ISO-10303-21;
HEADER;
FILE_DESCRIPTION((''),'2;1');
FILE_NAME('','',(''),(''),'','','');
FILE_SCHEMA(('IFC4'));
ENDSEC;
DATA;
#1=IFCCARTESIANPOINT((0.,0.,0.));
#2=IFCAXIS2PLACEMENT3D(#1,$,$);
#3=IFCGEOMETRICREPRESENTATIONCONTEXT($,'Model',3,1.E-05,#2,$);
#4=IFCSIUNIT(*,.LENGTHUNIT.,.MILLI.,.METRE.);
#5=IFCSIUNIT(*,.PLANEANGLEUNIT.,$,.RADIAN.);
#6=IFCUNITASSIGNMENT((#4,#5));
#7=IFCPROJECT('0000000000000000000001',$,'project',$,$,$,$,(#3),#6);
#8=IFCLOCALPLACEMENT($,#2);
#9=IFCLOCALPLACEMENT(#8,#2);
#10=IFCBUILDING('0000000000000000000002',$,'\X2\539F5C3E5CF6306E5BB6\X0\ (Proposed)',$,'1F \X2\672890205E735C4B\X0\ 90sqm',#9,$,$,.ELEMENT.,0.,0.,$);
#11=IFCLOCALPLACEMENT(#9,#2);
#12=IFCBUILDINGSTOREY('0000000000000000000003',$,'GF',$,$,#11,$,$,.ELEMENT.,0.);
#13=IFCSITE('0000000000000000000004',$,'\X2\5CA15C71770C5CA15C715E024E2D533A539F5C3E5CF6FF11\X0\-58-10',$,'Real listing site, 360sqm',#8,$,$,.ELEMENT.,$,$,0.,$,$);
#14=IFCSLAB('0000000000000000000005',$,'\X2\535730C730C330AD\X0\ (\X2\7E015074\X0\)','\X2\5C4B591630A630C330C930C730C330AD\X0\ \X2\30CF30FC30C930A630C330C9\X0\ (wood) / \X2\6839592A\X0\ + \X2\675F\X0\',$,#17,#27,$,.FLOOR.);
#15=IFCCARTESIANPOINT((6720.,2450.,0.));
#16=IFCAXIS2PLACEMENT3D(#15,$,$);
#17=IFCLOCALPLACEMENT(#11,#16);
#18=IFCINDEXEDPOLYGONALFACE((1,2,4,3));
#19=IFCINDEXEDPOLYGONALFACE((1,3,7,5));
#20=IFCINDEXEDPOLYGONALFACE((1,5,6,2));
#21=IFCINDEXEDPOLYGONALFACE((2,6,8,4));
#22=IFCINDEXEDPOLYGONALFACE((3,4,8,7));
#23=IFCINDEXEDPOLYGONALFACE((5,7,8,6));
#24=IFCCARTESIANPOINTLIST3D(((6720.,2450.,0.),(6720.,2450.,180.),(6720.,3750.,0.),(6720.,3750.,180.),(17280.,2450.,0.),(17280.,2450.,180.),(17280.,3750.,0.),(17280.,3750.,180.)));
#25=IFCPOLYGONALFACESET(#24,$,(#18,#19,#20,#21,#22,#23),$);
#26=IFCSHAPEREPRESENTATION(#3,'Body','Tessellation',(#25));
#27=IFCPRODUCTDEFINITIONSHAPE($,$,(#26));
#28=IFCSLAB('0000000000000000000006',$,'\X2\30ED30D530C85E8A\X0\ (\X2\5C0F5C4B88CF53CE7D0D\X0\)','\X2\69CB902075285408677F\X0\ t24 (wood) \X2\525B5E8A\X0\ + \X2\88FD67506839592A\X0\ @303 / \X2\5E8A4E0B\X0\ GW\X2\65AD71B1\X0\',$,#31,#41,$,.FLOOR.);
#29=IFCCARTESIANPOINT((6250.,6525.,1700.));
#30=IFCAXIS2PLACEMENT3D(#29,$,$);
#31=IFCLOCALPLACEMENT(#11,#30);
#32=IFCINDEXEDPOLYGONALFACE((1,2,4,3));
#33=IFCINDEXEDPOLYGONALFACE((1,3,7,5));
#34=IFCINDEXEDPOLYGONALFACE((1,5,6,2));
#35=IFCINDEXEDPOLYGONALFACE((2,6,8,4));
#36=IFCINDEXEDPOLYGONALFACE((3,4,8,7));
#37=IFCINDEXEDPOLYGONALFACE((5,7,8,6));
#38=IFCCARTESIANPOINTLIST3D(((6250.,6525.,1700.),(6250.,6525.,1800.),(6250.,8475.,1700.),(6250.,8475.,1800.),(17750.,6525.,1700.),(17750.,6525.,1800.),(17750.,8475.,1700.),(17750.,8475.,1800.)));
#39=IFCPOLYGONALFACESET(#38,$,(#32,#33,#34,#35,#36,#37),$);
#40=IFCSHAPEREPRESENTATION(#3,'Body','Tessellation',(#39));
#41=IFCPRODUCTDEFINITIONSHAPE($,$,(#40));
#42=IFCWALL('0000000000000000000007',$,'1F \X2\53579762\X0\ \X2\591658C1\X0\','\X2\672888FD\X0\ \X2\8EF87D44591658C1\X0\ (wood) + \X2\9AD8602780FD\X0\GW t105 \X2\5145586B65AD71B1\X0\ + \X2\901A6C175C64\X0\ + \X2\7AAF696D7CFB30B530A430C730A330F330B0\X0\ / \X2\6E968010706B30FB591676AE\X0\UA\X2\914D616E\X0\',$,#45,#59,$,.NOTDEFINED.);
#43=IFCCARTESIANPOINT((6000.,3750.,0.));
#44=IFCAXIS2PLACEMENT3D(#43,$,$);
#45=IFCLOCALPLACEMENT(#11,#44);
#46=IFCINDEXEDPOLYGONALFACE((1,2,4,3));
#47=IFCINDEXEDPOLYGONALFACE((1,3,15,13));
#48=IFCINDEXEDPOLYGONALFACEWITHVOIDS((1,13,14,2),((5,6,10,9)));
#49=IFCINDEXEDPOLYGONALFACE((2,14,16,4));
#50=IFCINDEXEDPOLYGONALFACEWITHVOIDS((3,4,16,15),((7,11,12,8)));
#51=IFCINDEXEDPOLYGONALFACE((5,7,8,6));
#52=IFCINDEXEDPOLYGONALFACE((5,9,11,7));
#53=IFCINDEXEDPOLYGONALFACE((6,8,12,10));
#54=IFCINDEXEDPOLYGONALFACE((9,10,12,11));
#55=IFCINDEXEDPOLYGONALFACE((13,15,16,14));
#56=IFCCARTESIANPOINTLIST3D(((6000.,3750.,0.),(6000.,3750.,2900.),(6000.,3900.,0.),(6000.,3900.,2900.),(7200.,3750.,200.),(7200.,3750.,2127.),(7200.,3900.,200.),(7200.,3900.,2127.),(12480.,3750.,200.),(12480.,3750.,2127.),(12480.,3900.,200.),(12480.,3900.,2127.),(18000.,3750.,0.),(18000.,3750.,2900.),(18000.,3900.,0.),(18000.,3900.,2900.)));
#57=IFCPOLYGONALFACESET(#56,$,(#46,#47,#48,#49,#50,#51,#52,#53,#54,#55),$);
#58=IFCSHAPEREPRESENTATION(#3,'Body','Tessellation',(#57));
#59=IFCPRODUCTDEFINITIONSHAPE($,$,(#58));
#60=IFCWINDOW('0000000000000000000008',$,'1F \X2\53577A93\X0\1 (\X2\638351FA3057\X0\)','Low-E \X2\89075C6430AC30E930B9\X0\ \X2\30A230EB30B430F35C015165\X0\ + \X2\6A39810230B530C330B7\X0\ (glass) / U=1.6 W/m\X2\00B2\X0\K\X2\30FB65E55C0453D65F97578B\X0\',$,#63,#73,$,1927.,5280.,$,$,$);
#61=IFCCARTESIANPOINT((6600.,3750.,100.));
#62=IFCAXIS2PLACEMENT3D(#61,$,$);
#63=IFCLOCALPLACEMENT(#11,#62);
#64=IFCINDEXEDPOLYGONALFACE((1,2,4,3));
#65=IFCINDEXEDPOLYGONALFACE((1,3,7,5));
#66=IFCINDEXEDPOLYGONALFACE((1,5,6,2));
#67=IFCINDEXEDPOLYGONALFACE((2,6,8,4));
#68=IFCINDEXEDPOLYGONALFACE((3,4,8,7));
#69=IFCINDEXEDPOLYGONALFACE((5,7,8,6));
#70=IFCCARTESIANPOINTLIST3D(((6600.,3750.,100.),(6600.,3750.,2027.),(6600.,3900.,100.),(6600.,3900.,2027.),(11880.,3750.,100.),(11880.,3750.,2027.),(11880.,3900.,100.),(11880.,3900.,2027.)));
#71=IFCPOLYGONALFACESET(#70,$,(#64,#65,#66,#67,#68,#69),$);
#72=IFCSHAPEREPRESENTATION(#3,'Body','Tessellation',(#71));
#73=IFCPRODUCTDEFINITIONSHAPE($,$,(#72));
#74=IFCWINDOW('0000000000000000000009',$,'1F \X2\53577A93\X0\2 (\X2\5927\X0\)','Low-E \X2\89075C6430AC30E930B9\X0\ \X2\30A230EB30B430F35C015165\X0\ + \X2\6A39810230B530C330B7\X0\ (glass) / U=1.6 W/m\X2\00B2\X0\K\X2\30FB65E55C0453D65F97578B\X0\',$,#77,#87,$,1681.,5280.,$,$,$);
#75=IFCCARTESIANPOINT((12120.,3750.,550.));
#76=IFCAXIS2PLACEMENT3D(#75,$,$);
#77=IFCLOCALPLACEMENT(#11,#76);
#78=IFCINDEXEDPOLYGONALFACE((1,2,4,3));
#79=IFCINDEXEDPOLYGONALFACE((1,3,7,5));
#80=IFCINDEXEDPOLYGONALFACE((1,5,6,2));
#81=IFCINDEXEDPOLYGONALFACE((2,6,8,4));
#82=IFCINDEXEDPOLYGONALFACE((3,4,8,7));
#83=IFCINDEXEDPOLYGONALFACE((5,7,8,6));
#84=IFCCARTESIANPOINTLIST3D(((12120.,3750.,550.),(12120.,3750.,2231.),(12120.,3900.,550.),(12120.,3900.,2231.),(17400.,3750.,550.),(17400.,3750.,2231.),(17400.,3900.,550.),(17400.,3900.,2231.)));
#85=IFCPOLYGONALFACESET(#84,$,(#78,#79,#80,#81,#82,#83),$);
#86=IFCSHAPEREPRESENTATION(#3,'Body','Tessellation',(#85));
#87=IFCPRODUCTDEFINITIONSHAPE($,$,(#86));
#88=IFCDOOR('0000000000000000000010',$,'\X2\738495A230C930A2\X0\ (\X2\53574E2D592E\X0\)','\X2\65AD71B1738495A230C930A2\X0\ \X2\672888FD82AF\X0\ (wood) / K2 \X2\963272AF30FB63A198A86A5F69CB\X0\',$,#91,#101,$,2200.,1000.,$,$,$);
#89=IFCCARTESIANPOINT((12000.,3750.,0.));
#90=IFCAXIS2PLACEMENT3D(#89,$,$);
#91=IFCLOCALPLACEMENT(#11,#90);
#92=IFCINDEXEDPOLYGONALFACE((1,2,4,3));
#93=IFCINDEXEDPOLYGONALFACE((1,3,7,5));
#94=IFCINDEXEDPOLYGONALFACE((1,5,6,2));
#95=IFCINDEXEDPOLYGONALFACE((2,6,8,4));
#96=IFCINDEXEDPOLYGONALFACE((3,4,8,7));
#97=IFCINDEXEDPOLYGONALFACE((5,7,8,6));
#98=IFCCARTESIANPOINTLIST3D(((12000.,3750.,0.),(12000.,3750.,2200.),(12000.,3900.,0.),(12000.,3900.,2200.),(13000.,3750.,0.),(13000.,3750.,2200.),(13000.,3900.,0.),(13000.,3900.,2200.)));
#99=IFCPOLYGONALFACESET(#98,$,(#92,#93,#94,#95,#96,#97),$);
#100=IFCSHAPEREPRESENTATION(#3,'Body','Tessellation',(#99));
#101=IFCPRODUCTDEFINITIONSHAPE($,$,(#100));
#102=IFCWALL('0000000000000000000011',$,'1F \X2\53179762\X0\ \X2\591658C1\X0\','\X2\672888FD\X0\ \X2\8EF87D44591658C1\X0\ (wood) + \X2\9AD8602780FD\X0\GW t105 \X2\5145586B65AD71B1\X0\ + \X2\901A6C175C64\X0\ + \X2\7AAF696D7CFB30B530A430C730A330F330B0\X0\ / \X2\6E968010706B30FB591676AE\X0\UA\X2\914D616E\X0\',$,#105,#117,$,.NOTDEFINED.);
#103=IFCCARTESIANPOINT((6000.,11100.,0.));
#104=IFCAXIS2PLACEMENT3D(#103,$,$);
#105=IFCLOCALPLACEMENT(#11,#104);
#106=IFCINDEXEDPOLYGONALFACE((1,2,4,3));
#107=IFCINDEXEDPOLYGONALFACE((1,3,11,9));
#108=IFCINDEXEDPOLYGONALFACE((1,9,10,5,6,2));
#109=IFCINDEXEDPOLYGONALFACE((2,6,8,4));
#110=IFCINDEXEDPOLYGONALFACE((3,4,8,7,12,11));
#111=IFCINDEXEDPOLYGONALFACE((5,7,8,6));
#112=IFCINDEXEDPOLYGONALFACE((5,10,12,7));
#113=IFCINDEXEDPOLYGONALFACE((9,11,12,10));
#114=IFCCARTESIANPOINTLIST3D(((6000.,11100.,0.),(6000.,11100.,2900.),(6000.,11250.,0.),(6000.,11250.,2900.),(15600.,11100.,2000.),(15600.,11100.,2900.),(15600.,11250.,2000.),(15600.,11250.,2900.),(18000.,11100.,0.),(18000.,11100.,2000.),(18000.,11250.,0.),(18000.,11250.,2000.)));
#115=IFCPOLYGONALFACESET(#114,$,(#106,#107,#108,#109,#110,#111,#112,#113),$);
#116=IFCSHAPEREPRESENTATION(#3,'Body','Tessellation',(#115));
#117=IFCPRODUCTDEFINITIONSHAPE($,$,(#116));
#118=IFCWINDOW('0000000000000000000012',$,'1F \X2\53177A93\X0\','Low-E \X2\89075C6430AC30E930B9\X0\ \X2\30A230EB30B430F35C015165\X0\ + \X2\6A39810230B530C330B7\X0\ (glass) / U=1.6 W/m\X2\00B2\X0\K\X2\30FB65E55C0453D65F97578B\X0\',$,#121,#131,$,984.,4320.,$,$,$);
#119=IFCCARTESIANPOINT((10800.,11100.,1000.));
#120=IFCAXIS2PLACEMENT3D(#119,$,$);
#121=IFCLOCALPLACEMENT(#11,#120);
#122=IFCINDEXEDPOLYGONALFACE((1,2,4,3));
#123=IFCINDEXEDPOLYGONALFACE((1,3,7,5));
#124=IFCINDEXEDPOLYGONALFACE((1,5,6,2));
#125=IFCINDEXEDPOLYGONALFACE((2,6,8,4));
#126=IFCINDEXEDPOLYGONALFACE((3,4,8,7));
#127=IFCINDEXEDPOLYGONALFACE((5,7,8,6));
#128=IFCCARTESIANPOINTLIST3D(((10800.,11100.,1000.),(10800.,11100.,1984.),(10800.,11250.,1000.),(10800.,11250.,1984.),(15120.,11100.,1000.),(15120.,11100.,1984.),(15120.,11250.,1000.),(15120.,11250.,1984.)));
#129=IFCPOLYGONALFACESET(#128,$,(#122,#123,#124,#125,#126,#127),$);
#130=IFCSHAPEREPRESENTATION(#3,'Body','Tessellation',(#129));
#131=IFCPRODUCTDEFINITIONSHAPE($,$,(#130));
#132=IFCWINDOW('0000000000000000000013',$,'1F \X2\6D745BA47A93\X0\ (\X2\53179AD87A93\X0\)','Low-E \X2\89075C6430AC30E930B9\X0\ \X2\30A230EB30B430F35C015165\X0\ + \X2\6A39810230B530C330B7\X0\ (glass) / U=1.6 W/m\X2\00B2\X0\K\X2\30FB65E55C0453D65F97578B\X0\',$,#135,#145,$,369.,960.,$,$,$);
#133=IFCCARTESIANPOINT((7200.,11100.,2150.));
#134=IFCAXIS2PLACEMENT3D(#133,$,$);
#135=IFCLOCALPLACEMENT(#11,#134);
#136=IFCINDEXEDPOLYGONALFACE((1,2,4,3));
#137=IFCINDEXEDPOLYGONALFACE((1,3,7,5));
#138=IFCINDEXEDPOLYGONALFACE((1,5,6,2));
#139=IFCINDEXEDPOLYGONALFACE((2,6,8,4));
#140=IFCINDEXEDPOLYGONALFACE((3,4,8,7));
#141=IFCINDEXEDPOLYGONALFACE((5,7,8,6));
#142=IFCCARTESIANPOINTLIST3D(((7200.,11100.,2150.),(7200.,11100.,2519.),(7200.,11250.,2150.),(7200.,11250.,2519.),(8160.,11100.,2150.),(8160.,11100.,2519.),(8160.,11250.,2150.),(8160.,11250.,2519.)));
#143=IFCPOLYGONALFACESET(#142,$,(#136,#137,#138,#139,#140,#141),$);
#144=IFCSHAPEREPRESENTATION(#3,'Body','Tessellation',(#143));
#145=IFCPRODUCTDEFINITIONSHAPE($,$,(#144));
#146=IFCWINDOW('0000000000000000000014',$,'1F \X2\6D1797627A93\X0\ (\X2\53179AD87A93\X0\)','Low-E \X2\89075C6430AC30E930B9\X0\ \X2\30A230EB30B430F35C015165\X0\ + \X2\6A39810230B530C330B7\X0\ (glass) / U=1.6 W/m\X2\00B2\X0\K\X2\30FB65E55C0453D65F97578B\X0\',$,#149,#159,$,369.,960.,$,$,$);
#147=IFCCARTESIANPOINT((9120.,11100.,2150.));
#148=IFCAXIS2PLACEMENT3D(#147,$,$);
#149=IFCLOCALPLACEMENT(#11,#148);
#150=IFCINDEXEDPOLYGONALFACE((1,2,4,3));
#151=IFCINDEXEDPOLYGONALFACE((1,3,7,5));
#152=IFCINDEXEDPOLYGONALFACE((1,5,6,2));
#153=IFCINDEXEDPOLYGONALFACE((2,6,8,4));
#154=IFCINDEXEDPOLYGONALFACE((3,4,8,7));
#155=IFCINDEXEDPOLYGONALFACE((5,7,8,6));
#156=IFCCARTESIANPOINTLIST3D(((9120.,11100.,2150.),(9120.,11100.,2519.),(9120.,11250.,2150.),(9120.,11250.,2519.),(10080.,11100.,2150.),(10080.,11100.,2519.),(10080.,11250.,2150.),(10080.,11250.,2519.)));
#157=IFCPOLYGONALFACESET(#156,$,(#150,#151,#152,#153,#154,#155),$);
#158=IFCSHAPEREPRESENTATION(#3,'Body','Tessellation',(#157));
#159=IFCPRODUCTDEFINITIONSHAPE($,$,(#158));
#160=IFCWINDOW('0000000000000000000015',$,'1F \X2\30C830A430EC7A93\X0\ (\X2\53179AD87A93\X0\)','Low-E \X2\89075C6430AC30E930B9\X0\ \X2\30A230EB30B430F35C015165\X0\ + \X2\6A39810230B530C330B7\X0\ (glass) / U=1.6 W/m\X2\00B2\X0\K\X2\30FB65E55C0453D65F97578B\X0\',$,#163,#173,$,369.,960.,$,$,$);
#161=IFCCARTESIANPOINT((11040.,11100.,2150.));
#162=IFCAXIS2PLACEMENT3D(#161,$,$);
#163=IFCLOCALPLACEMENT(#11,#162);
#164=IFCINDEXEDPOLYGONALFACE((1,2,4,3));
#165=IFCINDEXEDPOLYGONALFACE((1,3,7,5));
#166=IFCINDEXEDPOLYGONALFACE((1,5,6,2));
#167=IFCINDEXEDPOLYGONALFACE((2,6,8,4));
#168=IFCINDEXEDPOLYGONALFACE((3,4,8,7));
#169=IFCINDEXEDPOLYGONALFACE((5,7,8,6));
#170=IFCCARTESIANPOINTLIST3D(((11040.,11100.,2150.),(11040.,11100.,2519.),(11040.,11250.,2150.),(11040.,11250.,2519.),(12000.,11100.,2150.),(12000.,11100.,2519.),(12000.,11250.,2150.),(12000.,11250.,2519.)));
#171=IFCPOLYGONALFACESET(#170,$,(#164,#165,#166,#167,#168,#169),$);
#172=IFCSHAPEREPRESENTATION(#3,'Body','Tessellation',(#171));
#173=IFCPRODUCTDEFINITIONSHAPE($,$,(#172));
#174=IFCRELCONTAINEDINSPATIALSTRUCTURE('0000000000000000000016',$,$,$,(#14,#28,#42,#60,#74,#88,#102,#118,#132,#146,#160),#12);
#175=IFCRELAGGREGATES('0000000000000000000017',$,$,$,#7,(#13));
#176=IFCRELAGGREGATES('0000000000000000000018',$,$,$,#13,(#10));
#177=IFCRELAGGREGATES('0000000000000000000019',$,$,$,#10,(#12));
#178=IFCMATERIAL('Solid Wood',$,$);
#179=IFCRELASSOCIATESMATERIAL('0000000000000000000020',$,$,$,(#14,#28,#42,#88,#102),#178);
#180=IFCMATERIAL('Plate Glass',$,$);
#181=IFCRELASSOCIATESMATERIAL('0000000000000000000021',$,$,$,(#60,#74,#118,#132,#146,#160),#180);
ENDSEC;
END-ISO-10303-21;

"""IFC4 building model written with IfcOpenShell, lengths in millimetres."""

from ifc_helpers import new_model, si_unit, frame, frame_2d, origin, place, context, project, spatial, rectangle, extrude, material, element, fill, save


model = new_model("IFC4")

# Units and contexts
model_context = context("Model", 3, precision=1e-05, world=origin())
ifc_project = project(units=[si_unit("LENGTHUNIT", "METRE", prefix="MILLI"), si_unit("PLANEANGLEUNIT", "RADIAN")], contexts=[model_context])

# Site, building, storey
site_placement = place(None, origin())
site = spatial("IfcSite", under=ifc_project, at=site_placement, Name="岡山県岡山市中区原尾島１-58-10", ObjectType="Real listing site, 360sqm", CompositionType="ELEMENT", RefElevation=0.0)
building_placement = place(site_placement, origin())
building = spatial("IfcBuilding", under=site, at=building_placement, Name="原尾島の家 (Proposed)", ObjectType="1F 木造平屋 90sqm", CompositionType="ELEMENT", ElevationOfRefHeight=0.0, ElevationOfTerrain=0.0)
storey_placement = place(building_placement, origin())
storey = spatial("IfcBuildingStorey", under=building, at=storey_placement, Name="GF", CompositionType="ELEMENT", Elevation=0.0)

# Slabs
ifc_material_1 = material(Name="Solid Wood")
slab_1_placement = place(storey_placement, frame((6720.0, 2450.0, 0.0)))
element("IfcSlab", 1, at=slab_1_placement, inside=storey, material=ifc_material_1, Name="南デッキ (縁側)", Description="屋外ウッドデッキ ハードウッド (wood) / 根太 + 束", PredefinedType="FLOOR", context=model_context, shape_type="SweptSolid", body=[
    extrude(rectangle(XDim=10560.0, YDim=1300.0, at=frame_2d((5280.0, 650.0))), frame((6720.0, 2450.0, 0.0)), (0.0, 0.0, 1.0), 180.0),
])
slab_2_placement = place(storey_placement, frame((6250.0, 6525.0, 1700.0)))
element("IfcSlab", 2, at=slab_2_placement, inside=storey, material=ifc_material_1, Name="ロフト床 (小屋裏収納)", Description="構造用合板 t24 (wood) 剛床 + 製材根太 @303 / 床下 GW断熱", PredefinedType="FLOOR", context=model_context, shape_type="SweptSolid", body=[
    extrude(rectangle(XDim=11500.0, YDim=1950.0, at=frame_2d((5750.0, 975.0))), frame((6250.0, 6525.0, 1700.0)), (0.0, 0.0, 1.0), 100.0),
])

# Wall, openings, windows, door
wall_1_placement = place(storey_placement, frame((6000.0, 3750.0, 0.0)))
wall_1 = element("IfcWall", 3, at=wall_1_placement, inside=storey, material=ifc_material_1, Name="1F 南面 外壁", Description="木製 軸組外壁 (wood) + 高性能GW t105 充填断熱 + 通気層 + 窯業系サイディング / 準耐火・外皮UA配慮", PredefinedType="NOTDEFINED", context=model_context, shape_type="SweptSolid", body=[
    extrude(rectangle(XDim=12000.0, YDim=150.0, at=frame_2d((6000.0, 75.0))), frame((6000.0, 3750.0, 0.0)), (0.0, 0.0, 1.0), 2900.0),
])
opening_1_placement = place(storey_placement, frame((6600.0, 3750.0, 100.0)))
opening_1 = element("IfcOpeningElement", 4, at=opening_1_placement, cuts=wall_1, PredefinedType="NOTDEFINED", context=model_context, shape_type="SweptSolid", body=[
    extrude(rectangle(XDim=5280.0, YDim=150.0, at=frame_2d((2640.0, 75.0))), frame((6600.0, 3750.0, 100.0)), (0.0, 0.0, 1.0), 1927.0),
])
opening_2_placement = place(storey_placement, frame((12120.0, 3750.0, 550.0)))
opening_2 = element("IfcOpeningElement", 5, at=opening_2_placement, cuts=wall_1, PredefinedType="NOTDEFINED", context=model_context, shape_type="SweptSolid", body=[
    extrude(rectangle(XDim=5280.0, YDim=150.0, at=frame_2d((2640.0, 75.0))), frame((12120.0, 3750.0, 550.0)), (0.0, 0.0, 1.0), 1681.0),
])
opening_3_placement = place(storey_placement, frame((12000.0, 3750.0, 0.0)))
opening_3 = element("IfcOpeningElement", 6, at=opening_3_placement, cuts=wall_1, PredefinedType="NOTDEFINED", context=model_context, shape_type="SweptSolid", body=[
    extrude(rectangle(XDim=1000.0, YDim=150.0, at=frame_2d((500.0, 75.0))), frame((12000.0, 3750.0, 0.0)), (0.0, 0.0, 1.0), 2200.0),
])
ifc_material_2 = material(Name="Plate Glass")
window_1_placement = place(storey_placement, frame((6600.0, 3750.0, 100.0)))
window_1 = element("IfcWindow", 7, at=window_1_placement, inside=storey, material=ifc_material_2, Name="1F 南窓1 (掃出し)", Description="Low-E 複層ガラス アルゴン封入 + 樹脂サッシ (glass) / U=1.6 W/m²K・日射取得型", OverallHeight=1927.0, OverallWidth=5280.0, context=model_context, shape_type="SweptSolid", body=[
    extrude(rectangle(XDim=5280.0, YDim=150.0, at=frame_2d((2640.0, 75.0))), frame((6600.0, 3750.0, 100.0)), (0.0, 0.0, 1.0), 1927.0),
])
fill(opening_1, window_1)
window_2_placement = place(storey_placement, frame((12120.0, 3750.0, 550.0)))
window_2 = element("IfcWindow", 8, at=window_2_placement, inside=storey, material=ifc_material_2, Name="1F 南窓2 (大)", Description="Low-E 複層ガラス アルゴン封入 + 樹脂サッシ (glass) / U=1.6 W/m²K・日射取得型", OverallHeight=1681.0, OverallWidth=5280.0, context=model_context, shape_type="SweptSolid", body=[
    extrude(rectangle(XDim=5280.0, YDim=150.0, at=frame_2d((2640.0, 75.0))), frame((12120.0, 3750.0, 550.0)), (0.0, 0.0, 1.0), 1681.0),
])
fill(opening_2, window_2)
door_1_placement = place(storey_placement, frame((12000.0, 3750.0, 0.0)))
door_1 = element("IfcDoor", 9, at=door_1_placement, inside=storey, material=ifc_material_1, Name="玄関ドア (南中央)", Description="断熱玄関ドア 木製芯 (wood) / K2 防犯・採風機構", OverallHeight=2200.0, OverallWidth=1000.0, context=model_context, shape_type="SweptSolid", body=[
    extrude(rectangle(XDim=1000.0, YDim=150.0, at=frame_2d((500.0, 75.0))), frame((12000.0, 3750.0, 0.0)), (0.0, 0.0, 1.0), 2200.0),
])
fill(opening_3, door_1)

# Wall, openings, windows
wall_2_placement = place(storey_placement, frame((6000.0, 11100.0, 0.0)))
wall_2 = element("IfcWall", 10, at=wall_2_placement, inside=storey, material=ifc_material_1, Name="1F 北面 外壁", Description="木製 軸組外壁 (wood) + 高性能GW t105 充填断熱 + 通気層 + 窯業系サイディング / 準耐火・外皮UA配慮", PredefinedType="NOTDEFINED", context=model_context, shape_type="SweptSolid", body=[
    extrude(rectangle(XDim=12000.0, YDim=150.0, at=frame_2d((6000.0, 75.0))), frame((6000.0, 11100.0, 0.0)), (0.0, 0.0, 1.0), 2900.0),
])
opening_4_placement = place(storey_placement, frame((10800.0, 11100.0, 1000.0)))
opening_4 = element("IfcOpeningElement", 11, at=opening_4_placement, cuts=wall_2, PredefinedType="NOTDEFINED", context=model_context, shape_type="SweptSolid", body=[
    extrude(rectangle(XDim=4320.0, YDim=150.0, at=frame_2d((2160.0, 75.0))), frame((10800.0, 11100.0, 1000.0)), (0.0, 0.0, 1.0), 984.0),
])
opening_5_placement = place(storey_placement, frame((7200.0, 11100.0, 2150.0)))
opening_5 = element("IfcOpeningElement", 12, at=opening_5_placement, cuts=wall_2, PredefinedType="NOTDEFINED", context=model_context, shape_type="SweptSolid", body=[
    extrude(rectangle(XDim=960.0, YDim=150.0, at=frame_2d((480.0, 75.0))), frame((7200.0, 11100.0, 2150.0)), (0.0, 0.0, 1.0), 369.0),
])
opening_6_placement = place(storey_placement, frame((9120.0, 11100.0, 2150.0)))
opening_6 = element("IfcOpeningElement", 13, at=opening_6_placement, cuts=wall_2, PredefinedType="NOTDEFINED", context=model_context, shape_type="SweptSolid", body=[
    extrude(rectangle(XDim=960.0, YDim=150.0, at=frame_2d((480.0, 75.0))), frame((9120.0, 11100.0, 2150.0)), (0.0, 0.0, 1.0), 369.0),
])
opening_7_placement = place(storey_placement, frame((11040.0, 11100.0, 2150.0)))
opening_7 = element("IfcOpeningElement", 14, at=opening_7_placement, cuts=wall_2, PredefinedType="NOTDEFINED", context=model_context, shape_type="SweptSolid", body=[
    extrude(rectangle(XDim=960.0, YDim=150.0, at=frame_2d((480.0, 75.0))), frame((11040.0, 11100.0, 2150.0)), (0.0, 0.0, 1.0), 369.0),
])
window_3_placement = place(storey_placement, frame((10800.0, 11100.0, 1000.0)))
window_3 = element("IfcWindow", 15, at=window_3_placement, inside=storey, material=ifc_material_2, Name="1F 北窓", Description="Low-E 複層ガラス アルゴン封入 + 樹脂サッシ (glass) / U=1.6 W/m²K・日射取得型", OverallHeight=984.0, OverallWidth=4320.0, context=model_context, shape_type="SweptSolid", body=[
    extrude(rectangle(XDim=4320.0, YDim=150.0, at=frame_2d((2160.0, 75.0))), frame((10800.0, 11100.0, 1000.0)), (0.0, 0.0, 1.0), 984.0),
])
fill(opening_4, window_3)
window_4_placement = place(storey_placement, frame((7200.0, 11100.0, 2150.0)))
window_4 = element("IfcWindow", 16, at=window_4_placement, inside=storey, material=ifc_material_2, Name="1F 浴室窓 (北高窓)", Description="Low-E 複層ガラス アルゴン封入 + 樹脂サッシ (glass) / U=1.6 W/m²K・日射取得型", OverallHeight=369.0, OverallWidth=960.0, context=model_context, shape_type="SweptSolid", body=[
    extrude(rectangle(XDim=960.0, YDim=150.0, at=frame_2d((480.0, 75.0))), frame((7200.0, 11100.0, 2150.0)), (0.0, 0.0, 1.0), 369.0),
])
fill(opening_5, window_4)
window_5_placement = place(storey_placement, frame((9120.0, 11100.0, 2150.0)))
window_5 = element("IfcWindow", 17, at=window_5_placement, inside=storey, material=ifc_material_2, Name="1F 洗面窓 (北高窓)", Description="Low-E 複層ガラス アルゴン封入 + 樹脂サッシ (glass) / U=1.6 W/m²K・日射取得型", OverallHeight=369.0, OverallWidth=960.0, context=model_context, shape_type="SweptSolid", body=[
    extrude(rectangle(XDim=960.0, YDim=150.0, at=frame_2d((480.0, 75.0))), frame((9120.0, 11100.0, 2150.0)), (0.0, 0.0, 1.0), 369.0),
])
fill(opening_6, window_5)
window_6_placement = place(storey_placement, frame((11040.0, 11100.0, 2150.0)))
window_6 = element("IfcWindow", 18, at=window_6_placement, inside=storey, material=ifc_material_2, Name="1F トイレ窓 (北高窓)", Description="Low-E 複層ガラス アルゴン封入 + 樹脂サッシ (glass) / U=1.6 W/m²K・日射取得型", OverallHeight=369.0, OverallWidth=960.0, context=model_context, shape_type="SweptSolid", body=[
    extrude(rectangle(XDim=960.0, YDim=150.0, at=frame_2d((480.0, 75.0))), frame((11040.0, 11100.0, 2150.0)), (0.0, 0.0, 1.0), 369.0),
])
fill(opening_7, window_6)

save(model, "model.ifc")
